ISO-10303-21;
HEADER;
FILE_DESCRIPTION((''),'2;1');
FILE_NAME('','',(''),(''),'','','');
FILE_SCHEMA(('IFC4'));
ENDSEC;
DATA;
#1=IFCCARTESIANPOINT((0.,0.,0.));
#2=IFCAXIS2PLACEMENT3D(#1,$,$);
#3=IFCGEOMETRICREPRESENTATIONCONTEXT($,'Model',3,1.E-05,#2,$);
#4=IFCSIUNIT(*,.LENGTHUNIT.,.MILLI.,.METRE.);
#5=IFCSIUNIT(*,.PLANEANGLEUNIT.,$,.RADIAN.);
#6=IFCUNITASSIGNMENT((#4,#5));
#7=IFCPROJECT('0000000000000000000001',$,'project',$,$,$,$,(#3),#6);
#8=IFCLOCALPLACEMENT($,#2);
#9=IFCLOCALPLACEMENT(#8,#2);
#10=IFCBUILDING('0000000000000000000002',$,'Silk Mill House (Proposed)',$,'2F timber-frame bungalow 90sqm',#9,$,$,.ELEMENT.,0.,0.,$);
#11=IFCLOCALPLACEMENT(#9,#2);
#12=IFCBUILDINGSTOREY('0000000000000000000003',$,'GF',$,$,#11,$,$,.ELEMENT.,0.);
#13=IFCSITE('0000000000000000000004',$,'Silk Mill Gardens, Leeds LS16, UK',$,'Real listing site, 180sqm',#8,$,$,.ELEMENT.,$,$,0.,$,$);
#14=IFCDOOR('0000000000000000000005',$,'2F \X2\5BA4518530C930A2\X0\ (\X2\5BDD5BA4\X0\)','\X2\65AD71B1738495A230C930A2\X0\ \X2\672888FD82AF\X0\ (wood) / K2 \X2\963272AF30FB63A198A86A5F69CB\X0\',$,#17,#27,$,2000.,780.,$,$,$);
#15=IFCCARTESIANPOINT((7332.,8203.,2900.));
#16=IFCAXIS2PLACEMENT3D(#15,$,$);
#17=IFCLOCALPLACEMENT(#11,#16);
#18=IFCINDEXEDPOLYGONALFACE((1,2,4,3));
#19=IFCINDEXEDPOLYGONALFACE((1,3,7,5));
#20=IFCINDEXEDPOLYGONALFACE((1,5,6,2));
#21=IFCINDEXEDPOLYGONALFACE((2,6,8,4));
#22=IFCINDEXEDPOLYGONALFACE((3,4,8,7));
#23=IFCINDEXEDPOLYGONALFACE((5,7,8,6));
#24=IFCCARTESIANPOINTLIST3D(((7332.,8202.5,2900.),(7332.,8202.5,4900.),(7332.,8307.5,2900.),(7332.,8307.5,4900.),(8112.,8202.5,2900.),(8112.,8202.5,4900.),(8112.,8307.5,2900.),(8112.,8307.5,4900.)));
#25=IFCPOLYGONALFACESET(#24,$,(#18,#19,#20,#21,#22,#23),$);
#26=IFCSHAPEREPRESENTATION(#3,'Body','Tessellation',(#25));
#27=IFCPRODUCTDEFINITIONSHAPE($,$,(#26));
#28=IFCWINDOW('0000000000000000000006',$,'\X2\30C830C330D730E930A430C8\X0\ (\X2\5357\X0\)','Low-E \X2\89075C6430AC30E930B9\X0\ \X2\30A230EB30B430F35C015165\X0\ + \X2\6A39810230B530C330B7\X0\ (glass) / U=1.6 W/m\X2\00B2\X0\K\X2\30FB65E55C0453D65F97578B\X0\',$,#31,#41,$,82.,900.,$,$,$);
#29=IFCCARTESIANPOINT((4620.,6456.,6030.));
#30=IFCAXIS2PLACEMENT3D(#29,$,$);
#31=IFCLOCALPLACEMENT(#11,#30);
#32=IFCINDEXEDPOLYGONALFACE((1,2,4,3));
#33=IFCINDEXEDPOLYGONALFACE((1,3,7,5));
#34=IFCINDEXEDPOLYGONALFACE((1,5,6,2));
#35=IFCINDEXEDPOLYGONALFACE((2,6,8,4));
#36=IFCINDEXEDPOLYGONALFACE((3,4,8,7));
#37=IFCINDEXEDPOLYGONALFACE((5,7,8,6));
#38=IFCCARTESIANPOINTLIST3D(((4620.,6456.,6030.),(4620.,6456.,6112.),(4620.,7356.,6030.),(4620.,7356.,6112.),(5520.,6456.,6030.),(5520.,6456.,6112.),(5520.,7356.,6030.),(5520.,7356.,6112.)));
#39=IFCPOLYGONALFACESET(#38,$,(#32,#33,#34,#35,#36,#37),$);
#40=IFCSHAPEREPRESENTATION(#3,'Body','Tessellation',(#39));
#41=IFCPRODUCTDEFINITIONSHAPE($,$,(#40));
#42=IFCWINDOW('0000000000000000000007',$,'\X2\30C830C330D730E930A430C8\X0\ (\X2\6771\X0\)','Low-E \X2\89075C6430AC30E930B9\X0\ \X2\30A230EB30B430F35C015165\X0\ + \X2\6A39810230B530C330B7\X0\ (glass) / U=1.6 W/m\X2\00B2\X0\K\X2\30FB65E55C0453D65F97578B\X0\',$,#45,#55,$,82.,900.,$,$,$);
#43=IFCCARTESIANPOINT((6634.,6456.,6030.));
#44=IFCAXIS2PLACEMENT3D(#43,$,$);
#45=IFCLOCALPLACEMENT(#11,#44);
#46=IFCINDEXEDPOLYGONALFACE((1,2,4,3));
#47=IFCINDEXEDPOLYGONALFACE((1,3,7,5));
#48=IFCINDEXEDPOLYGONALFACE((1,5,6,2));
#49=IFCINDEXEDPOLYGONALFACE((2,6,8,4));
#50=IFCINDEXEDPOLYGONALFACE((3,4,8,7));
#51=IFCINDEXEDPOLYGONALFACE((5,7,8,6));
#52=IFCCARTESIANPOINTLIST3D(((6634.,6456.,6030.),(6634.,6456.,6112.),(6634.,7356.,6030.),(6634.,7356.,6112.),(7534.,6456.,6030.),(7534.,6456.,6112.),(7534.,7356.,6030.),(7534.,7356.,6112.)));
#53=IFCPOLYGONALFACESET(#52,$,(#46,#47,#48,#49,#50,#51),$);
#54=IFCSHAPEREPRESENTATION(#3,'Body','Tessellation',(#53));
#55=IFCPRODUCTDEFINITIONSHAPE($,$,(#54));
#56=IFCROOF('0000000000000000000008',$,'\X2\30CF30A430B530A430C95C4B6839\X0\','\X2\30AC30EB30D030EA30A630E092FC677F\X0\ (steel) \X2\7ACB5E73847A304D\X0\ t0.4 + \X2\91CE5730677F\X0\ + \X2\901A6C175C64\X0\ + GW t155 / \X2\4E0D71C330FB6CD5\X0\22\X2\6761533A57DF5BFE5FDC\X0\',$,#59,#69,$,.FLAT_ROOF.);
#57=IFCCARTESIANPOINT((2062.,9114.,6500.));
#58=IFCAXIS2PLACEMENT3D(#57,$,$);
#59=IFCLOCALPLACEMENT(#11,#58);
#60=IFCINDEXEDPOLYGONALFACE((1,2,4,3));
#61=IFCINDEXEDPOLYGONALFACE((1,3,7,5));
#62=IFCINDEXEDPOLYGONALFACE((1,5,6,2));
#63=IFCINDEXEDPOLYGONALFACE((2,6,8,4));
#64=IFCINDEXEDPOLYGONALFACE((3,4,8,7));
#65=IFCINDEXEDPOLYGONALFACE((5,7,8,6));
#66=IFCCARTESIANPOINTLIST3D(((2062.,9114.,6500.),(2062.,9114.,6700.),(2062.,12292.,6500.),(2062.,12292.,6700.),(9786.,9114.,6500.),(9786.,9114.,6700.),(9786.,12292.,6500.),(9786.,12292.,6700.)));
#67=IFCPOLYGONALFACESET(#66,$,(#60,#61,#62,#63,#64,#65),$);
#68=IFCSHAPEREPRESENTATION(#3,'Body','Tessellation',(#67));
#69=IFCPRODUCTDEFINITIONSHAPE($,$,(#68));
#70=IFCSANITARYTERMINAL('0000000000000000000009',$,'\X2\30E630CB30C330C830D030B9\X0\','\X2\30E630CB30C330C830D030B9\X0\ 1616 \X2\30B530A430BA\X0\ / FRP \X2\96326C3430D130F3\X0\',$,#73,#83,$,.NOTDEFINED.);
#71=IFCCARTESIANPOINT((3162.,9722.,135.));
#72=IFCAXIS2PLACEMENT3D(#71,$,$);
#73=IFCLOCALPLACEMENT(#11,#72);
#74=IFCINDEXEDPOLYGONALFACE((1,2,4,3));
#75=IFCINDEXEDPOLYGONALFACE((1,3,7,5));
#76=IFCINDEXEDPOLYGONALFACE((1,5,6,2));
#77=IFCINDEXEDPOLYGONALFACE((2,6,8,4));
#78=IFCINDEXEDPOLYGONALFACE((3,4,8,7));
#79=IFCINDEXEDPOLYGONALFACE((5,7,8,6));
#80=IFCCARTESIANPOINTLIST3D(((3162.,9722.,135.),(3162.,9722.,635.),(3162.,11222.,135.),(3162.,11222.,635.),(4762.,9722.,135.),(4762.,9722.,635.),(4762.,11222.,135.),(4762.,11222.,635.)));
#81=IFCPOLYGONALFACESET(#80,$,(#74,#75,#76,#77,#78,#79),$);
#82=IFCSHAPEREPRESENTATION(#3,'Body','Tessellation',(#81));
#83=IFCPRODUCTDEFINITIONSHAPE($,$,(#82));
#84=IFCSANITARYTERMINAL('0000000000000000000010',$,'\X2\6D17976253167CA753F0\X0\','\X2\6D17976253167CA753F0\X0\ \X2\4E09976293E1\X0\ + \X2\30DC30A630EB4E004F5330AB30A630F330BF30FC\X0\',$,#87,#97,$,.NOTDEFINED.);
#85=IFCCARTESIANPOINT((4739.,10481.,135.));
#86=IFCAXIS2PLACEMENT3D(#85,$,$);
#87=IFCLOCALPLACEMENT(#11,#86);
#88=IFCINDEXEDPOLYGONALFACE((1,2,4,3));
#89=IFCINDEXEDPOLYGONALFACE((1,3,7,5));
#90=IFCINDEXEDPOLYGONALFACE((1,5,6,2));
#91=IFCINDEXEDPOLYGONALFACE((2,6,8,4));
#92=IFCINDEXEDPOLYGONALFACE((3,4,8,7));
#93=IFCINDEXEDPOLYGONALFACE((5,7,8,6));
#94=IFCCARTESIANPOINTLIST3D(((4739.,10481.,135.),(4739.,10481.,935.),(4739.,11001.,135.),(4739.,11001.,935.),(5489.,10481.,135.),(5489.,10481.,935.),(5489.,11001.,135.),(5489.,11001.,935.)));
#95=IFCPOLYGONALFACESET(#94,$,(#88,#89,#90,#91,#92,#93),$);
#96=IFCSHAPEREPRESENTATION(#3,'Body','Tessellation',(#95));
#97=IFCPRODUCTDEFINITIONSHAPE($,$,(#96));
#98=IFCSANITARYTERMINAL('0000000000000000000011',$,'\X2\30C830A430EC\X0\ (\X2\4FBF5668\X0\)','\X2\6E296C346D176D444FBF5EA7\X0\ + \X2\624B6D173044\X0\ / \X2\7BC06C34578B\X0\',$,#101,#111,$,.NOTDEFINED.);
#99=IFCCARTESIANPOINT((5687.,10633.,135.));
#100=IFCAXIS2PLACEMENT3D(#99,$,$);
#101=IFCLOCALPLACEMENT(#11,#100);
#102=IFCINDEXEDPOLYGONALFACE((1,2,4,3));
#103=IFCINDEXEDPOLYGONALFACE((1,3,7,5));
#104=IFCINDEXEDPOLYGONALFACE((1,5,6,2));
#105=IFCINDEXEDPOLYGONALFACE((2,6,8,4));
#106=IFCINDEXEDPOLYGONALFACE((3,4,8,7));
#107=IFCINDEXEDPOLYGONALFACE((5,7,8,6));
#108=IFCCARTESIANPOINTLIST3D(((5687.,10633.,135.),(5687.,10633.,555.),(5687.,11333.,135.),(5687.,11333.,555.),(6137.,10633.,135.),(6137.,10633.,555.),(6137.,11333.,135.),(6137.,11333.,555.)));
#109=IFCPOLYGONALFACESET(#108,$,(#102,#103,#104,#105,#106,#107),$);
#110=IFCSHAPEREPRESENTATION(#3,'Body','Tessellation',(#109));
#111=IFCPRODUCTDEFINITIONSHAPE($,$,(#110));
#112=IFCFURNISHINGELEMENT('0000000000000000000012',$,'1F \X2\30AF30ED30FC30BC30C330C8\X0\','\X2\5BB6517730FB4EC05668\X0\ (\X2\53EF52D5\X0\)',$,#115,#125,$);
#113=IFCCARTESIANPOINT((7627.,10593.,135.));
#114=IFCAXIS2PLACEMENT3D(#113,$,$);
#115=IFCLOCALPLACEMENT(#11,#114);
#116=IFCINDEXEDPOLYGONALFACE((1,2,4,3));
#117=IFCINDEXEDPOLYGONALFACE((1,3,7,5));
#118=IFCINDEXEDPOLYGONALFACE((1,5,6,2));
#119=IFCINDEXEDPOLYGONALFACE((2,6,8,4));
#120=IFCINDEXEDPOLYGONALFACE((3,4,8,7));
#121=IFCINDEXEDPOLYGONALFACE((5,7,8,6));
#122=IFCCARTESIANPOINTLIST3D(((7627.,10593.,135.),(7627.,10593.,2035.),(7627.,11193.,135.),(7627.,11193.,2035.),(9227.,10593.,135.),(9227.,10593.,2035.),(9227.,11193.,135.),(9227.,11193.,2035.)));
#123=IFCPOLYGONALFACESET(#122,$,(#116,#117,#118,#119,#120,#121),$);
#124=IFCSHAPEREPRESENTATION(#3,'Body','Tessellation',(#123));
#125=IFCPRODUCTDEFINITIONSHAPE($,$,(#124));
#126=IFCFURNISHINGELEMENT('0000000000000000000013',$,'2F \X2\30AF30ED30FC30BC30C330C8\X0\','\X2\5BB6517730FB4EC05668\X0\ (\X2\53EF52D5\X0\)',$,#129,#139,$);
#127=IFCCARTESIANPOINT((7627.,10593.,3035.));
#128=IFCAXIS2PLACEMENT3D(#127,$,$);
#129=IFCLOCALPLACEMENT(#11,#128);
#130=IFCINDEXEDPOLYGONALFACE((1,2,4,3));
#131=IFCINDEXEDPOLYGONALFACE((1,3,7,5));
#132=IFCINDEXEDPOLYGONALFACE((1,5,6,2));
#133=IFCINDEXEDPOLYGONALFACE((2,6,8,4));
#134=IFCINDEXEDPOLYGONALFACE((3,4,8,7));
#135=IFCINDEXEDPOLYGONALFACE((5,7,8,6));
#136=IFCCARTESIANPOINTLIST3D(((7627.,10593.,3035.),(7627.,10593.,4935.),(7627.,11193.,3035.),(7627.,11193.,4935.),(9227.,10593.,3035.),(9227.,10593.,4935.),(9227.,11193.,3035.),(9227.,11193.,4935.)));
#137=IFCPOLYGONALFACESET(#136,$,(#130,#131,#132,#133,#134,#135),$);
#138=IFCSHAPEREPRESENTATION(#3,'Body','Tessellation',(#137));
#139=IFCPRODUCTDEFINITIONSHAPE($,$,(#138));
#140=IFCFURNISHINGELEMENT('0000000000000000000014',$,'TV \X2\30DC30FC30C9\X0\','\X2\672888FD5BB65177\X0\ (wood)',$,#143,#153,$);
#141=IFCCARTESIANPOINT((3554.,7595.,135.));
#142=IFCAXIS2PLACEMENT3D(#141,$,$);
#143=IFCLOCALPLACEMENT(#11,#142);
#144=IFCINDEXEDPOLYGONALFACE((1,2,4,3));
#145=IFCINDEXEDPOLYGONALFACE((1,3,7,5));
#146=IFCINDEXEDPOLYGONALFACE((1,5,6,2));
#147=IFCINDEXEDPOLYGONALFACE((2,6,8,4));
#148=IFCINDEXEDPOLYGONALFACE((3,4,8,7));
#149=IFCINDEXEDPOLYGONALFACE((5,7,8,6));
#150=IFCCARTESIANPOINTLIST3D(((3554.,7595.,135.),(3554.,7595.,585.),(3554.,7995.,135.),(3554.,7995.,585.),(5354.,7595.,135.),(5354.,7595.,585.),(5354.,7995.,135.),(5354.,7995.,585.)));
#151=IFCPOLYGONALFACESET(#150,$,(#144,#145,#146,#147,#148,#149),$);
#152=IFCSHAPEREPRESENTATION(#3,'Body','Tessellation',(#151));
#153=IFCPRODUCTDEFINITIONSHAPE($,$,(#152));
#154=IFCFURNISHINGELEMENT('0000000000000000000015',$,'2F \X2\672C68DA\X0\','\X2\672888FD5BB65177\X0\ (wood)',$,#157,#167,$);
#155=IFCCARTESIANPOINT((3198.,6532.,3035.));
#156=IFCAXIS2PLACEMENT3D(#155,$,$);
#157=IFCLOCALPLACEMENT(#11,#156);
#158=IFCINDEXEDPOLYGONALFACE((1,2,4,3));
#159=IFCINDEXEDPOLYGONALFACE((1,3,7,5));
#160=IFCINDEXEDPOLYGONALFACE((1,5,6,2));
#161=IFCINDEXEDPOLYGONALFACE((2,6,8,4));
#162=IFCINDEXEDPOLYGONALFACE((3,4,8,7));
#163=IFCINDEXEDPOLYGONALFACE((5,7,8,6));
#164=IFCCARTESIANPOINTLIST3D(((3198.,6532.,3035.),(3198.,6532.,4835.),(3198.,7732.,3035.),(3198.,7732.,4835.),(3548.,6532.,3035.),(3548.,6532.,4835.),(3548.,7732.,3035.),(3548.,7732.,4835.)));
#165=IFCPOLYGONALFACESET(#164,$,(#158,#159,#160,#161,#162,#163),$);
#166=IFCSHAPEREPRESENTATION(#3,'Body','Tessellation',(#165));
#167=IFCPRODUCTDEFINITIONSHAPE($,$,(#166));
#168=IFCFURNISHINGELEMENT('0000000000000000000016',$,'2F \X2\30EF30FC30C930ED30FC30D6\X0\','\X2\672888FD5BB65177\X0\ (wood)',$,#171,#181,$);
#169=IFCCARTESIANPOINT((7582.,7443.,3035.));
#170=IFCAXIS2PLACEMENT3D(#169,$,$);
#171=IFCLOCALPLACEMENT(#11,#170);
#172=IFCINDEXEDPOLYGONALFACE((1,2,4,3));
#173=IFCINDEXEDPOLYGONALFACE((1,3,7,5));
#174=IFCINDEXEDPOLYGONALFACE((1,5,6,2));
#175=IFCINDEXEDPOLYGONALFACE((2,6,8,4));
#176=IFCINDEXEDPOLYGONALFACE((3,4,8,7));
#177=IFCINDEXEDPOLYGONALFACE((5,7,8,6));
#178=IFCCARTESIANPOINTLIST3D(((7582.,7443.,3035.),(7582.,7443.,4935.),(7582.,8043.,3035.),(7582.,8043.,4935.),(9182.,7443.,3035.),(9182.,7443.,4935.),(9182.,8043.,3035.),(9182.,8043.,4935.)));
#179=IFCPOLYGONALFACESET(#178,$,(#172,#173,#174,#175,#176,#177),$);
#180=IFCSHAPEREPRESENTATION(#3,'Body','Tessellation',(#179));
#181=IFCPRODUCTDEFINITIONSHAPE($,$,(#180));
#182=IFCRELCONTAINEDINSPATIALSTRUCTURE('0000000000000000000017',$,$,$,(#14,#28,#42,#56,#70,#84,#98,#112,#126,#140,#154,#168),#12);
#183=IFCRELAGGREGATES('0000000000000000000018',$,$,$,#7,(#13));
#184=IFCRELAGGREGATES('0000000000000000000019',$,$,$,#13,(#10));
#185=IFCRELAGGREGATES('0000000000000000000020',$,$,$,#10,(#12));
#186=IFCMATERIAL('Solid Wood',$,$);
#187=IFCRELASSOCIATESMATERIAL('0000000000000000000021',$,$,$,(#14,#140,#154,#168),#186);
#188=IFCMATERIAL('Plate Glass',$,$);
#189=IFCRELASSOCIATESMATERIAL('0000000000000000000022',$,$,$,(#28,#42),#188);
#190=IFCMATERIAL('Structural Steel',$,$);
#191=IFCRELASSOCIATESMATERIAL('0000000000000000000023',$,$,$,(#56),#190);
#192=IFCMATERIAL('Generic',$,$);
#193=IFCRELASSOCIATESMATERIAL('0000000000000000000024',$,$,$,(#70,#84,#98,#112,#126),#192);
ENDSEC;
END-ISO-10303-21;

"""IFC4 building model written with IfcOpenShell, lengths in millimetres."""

from ifc_helpers import new_model, si_unit, frame, frame_2d, origin, place, context, project, spatial, rectangle, extrude, material, element, save


model = new_model("IFC4")

# Units and contexts
model_context = context("Model", 3, precision=1e-05, world=origin())
ifc_project = project(units=[si_unit("LENGTHUNIT", "METRE", prefix="MILLI"), si_unit("PLANEANGLEUNIT", "RADIAN")], contexts=[model_context])

# Site, building, storey
site_placement = place(None, origin())
site = spatial("IfcSite", under=ifc_project, at=site_placement, Name="Silk Mill Gardens, Leeds LS16, UK", ObjectType="Real listing site, 180sqm", CompositionType="ELEMENT", RefElevation=0.0)
building_placement = place(site_placement, origin())
building = spatial("IfcBuilding", under=site, at=building_placement, Name="Silk Mill House (Proposed)", ObjectType="2F timber-frame bungalow 90sqm", CompositionType="ELEMENT", ElevationOfRefHeight=0.0, ElevationOfTerrain=0.0)
storey_placement = place(building_placement, origin())
storey = spatial("IfcBuildingStorey", under=building, at=storey_placement, Name="GF", CompositionType="ELEMENT", Elevation=0.0)

# Shared definitions
ifc_material_1 = material(Name="Solid Wood")
ifc_material_2 = material(Name="Plate Glass")

# Door
door_1_placement = place(storey_placement, frame((7332.0, 8203.0, 2900.0)))
element("IfcDoor", 1, at=door_1_placement, inside=storey, material=ifc_material_1, Name="2F 室内ドア (寝室)", Description="断熱玄関ドア 木製芯 (wood) / K2 防犯・採風機構", OverallHeight=2000.0, OverallWidth=780.0, context=model_context, shape_type="SweptSolid", body=[
    extrude(rectangle(XDim=780.0, YDim=105.0, at=frame_2d((390.0, 52.0))), frame((7332.0, 8203.0, 2900.0)), (0.0, 0.0, 1.0), 2000.0),
])

# Windows
window_1_placement = place(storey_placement, frame((4620.0, 6456.0, 6030.0)))
element("IfcWindow", 2, at=window_1_placement, inside=storey, material=ifc_material_2, Name="トップライト (南)", Description="Low-E 複層ガラス アルゴン封入 + 樹脂サッシ (glass) / U=1.6 W/m²K・日射取得型", OverallHeight=82.0, OverallWidth=900.0, context=model_context, shape_type="SweptSolid", body=[
    extrude(rectangle(XDim=900.0, YDim=900.0, at=frame_2d((450.0, 450.0))), frame((4620.0, 6456.0, 6030.0)), (0.0, 0.0, 1.0), 82.0),
])
window_2_placement = place(storey_placement, frame((6634.0, 6456.0, 6030.0)))
element("IfcWindow", 3, at=window_2_placement, inside=storey, material=ifc_material_2, Name="トップライト (東)", Description="Low-E 複層ガラス アルゴン封入 + 樹脂サッシ (glass) / U=1.6 W/m²K・日射取得型", OverallHeight=82.0, OverallWidth=900.0, context=model_context, shape_type="SweptSolid", body=[
    extrude(rectangle(XDim=900.0, YDim=900.0, at=frame_2d((450.0, 450.0))), frame((6634.0, 6456.0, 6030.0)), (0.0, 0.0, 1.0), 82.0),
])

# Roof
ifc_material_3 = material(Name="Structural Steel")
roof_placement = place(storey_placement, frame((2062.0, 9114.0, 6500.0)))
element("IfcRoof", 4, at=roof_placement, inside=storey, material=ifc_material_3, Name="ハイサイド屋根", Description="ガルバリウム鋼板 (steel) 立平葺き t0.4 + 野地板 + 通気層 + GW t155 / 不燃・法22条区域対応", PredefinedType="FLAT_ROOF", context=model_context, shape_type="SweptSolid", body=[
    extrude(rectangle(XDim=7724.0, YDim=3178.0, at=frame_2d((3862.0, 1589.0))), frame((2062.0, 9114.0, 6500.0)), (0.0, 0.0, 1.0), 200.0),
])

# Sanitary terminals
ifc_material_4 = material(Name="Generic")
sanitary_terminal_1_placement = place(storey_placement, frame((3162.0, 9722.0, 135.0)))
element("IfcSanitaryTerminal", 5, at=sanitary_terminal_1_placement, inside=storey, material=ifc_material_4, Name="ユニットバス", Description="ユニットバス 1616 サイズ / FRP 防水パン", PredefinedType="NOTDEFINED", context=model_context, shape_type="SweptSolid", body=[
    extrude(rectangle(XDim=1600.0, YDim=1500.0, at=frame_2d((800.0, 750.0))), frame((3162.0, 9722.0, 135.0)), (0.0, 0.0, 1.0), 500.0),
])
sanitary_terminal_2_placement = place(storey_placement, frame((4739.0, 10481.0, 135.0)))
element("IfcSanitaryTerminal", 6, at=sanitary_terminal_2_placement, inside=storey, material=ifc_material_4, Name="洗面化粧台", Description="洗面化粧台 三面鏡 + ボウル一体カウンター", PredefinedType="NOTDEFINED", context=model_context, shape_type="SweptSolid", body=[
    extrude(rectangle(XDim=750.0, YDim=520.0, at=frame_2d((375.0, 260.0))), frame((4739.0, 10481.0, 135.0)), (0.0, 0.0, 1.0), 800.0),
])
sanitary_terminal_3_placement = place(storey_placement, frame((5687.0, 10633.0, 135.0)))
element("IfcSanitaryTerminal", 7, at=sanitary_terminal_3_placement, inside=storey, material=ifc_material_4, Name="トイレ (便器)", Description="温水洗浄便座 + 手洗い / 節水型", PredefinedType="NOTDEFINED", context=model_context, shape_type="SweptSolid", body=[
    extrude(rectangle(XDim=450.0, YDim=700.0, at=frame_2d((225.0, 350.0))), frame((5687.0, 10633.0, 135.0)), (0.0, 0.0, 1.0), 420.0),
])

# Furnishing elements
furnishing_1_placement = place(storey_placement, frame((7627.0, 10593.0, 135.0)))
element("IfcFurnishingElement", 8, at=furnishing_1_placement, inside=storey, material=ifc_material_4, Name="1F クローゼット", Description="家具・什器 (可動)", context=model_context, shape_type="SweptSolid", body=[
    extrude(rectangle(XDim=1600.0, YDim=600.0, at=frame_2d((800.0, 300.0))), frame((7627.0, 10593.0, 135.0)), (0.0, 0.0, 1.0), 1900.0),
])
furnishing_2_placement = place(storey_placement, frame((7627.0, 10593.0, 3035.0)))
element("IfcFurnishingElement", 9, at=furnishing_2_placement, inside=storey, material=ifc_material_4, Name="2F クローゼット", Description="家具・什器 (可動)", context=model_context, shape_type="SweptSolid", body=[
    extrude(rectangle(XDim=1600.0, YDim=600.0, at=frame_2d((800.0, 300.0))), frame((7627.0, 10593.0, 3035.0)), (0.0, 0.0, 1.0), 1900.0),
])
furnishing_3_placement = place(storey_placement, frame((3554.0, 7595.0, 135.0)))
element("IfcFurnishingElement", 10, at=furnishing_3_placement, inside=storey, material=ifc_material_1, Name="TV ボード", Description="木製家具 (wood)", context=model_context, shape_type="SweptSolid", body=[
    extrude(rectangle(XDim=1800.0, YDim=400.0, at=frame_2d((900.0, 200.0))), frame((3554.0, 7595.0, 135.0)), (0.0, 0.0, 1.0), 450.0),
])
furnishing_4_placement = place(storey_placement, frame((3198.0, 6532.0, 3035.0)))
element("IfcFurnishingElement", 11, at=furnishing_4_placement, inside=storey, material=ifc_material_1, Name="2F 本棚", Description="木製家具 (wood)", context=model_context, shape_type="SweptSolid", body=[
    extrude(rectangle(XDim=350.0, YDim=1200.0, at=frame_2d((175.0, 600.0))), frame((3198.0, 6532.0, 3035.0)), (0.0, 0.0, 1.0), 1800.0),
])
furnishing_5_placement = place(storey_placement, frame((7582.0, 7443.0, 3035.0)))
element("IfcFurnishingElement", 12, at=furnishing_5_placement, inside=storey, material=ifc_material_1, Name="2F ワードローブ", Description="木製家具 (wood)", context=model_context, shape_type="SweptSolid", body=[
    extrude(rectangle(XDim=1600.0, YDim=600.0, at=frame_2d((800.0, 300.0))), frame((7582.0, 7443.0, 3035.0)), (0.0, 0.0, 1.0), 1900.0),
])

save(model, "model.ifc")
